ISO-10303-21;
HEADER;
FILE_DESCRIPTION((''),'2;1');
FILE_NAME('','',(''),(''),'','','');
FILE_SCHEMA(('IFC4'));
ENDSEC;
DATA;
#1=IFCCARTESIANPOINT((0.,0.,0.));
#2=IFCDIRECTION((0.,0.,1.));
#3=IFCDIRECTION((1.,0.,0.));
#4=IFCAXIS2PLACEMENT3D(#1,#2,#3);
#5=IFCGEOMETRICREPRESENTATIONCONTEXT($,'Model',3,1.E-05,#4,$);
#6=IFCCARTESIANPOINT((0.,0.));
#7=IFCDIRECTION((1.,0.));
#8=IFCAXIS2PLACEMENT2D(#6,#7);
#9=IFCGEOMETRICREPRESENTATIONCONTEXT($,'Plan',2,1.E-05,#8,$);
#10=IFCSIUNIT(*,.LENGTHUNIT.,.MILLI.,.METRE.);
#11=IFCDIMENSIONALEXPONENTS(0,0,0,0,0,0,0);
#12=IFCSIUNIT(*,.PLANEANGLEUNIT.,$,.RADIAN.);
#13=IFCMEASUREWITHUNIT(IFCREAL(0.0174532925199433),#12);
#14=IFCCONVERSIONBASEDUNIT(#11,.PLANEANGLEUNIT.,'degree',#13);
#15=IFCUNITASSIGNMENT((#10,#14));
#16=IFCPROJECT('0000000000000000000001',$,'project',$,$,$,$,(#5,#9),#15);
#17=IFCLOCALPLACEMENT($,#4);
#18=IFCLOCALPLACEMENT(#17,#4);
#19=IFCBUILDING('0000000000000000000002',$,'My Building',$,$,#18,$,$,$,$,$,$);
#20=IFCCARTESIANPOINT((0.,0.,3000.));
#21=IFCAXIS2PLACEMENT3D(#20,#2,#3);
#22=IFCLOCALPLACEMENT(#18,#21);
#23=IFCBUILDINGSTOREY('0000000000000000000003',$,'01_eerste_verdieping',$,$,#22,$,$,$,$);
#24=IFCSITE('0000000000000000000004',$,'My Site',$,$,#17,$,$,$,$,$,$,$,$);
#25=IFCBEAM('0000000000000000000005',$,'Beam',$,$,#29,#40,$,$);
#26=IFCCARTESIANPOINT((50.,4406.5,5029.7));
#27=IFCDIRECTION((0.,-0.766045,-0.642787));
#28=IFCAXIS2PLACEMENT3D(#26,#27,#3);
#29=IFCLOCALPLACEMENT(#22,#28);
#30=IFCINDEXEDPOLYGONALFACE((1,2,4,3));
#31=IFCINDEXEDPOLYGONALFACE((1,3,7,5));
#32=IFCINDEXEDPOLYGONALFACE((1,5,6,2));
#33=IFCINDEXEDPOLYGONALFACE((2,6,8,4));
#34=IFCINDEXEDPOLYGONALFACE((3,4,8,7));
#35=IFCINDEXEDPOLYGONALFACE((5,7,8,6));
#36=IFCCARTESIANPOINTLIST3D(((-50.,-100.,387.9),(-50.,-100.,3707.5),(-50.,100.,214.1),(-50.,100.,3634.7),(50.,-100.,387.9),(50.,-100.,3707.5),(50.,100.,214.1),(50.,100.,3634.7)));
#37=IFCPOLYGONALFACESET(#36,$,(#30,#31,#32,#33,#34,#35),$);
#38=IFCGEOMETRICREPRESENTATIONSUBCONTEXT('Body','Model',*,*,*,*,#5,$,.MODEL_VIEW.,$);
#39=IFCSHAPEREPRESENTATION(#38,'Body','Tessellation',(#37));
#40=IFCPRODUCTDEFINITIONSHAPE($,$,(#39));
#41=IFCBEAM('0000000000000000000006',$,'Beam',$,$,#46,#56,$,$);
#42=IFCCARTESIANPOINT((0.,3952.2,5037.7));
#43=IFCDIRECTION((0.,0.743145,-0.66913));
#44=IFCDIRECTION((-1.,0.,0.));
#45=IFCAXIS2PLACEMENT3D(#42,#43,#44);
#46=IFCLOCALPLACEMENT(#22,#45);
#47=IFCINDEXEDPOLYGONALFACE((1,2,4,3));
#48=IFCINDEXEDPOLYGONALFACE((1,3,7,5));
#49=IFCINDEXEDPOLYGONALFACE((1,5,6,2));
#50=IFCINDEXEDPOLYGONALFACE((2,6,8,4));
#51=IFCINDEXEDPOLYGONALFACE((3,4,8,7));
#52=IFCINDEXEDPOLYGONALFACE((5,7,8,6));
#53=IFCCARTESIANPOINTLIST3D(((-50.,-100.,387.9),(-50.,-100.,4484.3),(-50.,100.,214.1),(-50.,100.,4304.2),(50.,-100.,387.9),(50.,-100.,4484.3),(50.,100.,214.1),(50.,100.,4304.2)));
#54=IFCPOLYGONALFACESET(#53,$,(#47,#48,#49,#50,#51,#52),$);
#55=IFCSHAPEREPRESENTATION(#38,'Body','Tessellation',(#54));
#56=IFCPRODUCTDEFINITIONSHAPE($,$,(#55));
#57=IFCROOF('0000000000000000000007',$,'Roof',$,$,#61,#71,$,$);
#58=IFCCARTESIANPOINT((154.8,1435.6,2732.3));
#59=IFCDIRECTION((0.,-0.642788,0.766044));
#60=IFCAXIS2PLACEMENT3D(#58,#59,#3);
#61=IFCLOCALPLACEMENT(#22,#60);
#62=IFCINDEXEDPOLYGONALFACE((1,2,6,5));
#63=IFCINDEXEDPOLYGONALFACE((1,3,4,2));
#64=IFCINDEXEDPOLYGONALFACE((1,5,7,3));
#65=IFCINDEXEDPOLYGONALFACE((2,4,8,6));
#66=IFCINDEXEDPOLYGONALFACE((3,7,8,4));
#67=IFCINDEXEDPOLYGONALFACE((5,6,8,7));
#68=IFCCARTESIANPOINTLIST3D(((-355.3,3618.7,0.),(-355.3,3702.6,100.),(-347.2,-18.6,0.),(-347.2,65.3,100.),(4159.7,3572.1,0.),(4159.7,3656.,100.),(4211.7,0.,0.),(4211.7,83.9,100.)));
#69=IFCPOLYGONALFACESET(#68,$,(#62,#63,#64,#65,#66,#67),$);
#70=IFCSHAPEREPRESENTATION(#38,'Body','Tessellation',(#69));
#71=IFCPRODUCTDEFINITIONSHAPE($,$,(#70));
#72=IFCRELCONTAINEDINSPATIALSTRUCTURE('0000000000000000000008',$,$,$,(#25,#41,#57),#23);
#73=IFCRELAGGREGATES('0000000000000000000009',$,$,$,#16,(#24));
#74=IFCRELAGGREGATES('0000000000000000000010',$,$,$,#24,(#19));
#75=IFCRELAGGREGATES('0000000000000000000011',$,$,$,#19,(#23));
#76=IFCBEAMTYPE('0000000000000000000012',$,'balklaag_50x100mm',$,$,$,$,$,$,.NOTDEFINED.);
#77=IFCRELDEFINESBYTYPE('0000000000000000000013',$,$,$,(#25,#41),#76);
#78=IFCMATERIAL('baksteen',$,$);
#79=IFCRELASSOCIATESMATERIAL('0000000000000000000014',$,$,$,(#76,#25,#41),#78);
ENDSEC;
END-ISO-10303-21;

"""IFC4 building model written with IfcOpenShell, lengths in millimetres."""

from ifc_helpers import new_model, entity, si_unit, converted_unit, frame, origin_with_axes, origin_2d_with_axis, place, context, subcontext, project, spatial, line, indexed_curve, rectangle, outline, extrude, clip, halfspace, material, material_profile, profile_set, profile_usage, type_object, element, save


model = new_model("IFC4")

# Units and contexts
model_context = context("Model", 3, precision=1e-05, world=origin_with_axes())
plan_context = context("Plan", 2, precision=1e-05, world=origin_2d_with_axis())
body_context = subcontext(model_context, "Body", "Model", "MODEL_VIEW")
ifc_project = project(units=[si_unit("LENGTHUNIT", "METRE", prefix="MILLI"), converted_unit("PLANEANGLEUNIT", "degree", entity("IfcReal", 0.0174532925199433), si_unit("PLANEANGLEUNIT", "RADIAN"), dimensions=[0, 0, 0, 0, 0, 0, 0])], contexts=[model_context, plan_context])

# Site, building, storey
site_placement = place(None, origin_with_axes())
site = spatial("IfcSite", under=ifc_project, at=site_placement, Name="My Site")
building_placement = place(site_placement, origin_with_axes())
building = spatial("IfcBuilding", under=site, at=building_placement, Name="My Building")
storey_placement = place(building_placement, frame((0.0, 0.0, 3000.0), z_axis=(0.0, 0.0, 1.0), x_axis=(1.0, 0.0, 0.0)))
storey = spatial("IfcBuildingStorey", under=building, at=storey_placement, Name="01_eerste_verdieping")

# Beams
ifc_material = material(Name="baksteen")
ifc_material_profile_1 = material_profile(ifc_material, rectangle(XDim=100.0, YDim=200.0))
ifc_profile_set_1 = profile_set([ifc_material_profile_1])
beam_type_1 = type_object("IfcBeamType", Name="balklaag_50x100mm", PredefinedType="NOTDEFINED", material=ifc_profile_set_1)
ifc_profile_usage_1 = profile_usage(ifc_profile_set_1, cardinal=5)
beam_1_placement = place(storey_placement, frame((50.0, 4406.5, 5029.7), z_axis=(0.0, -0.766045, -0.642787), x_axis=(1.0, 0.0, 0.0)))
element("IfcBeam", 1, at=beam_1_placement, inside=storey, type_object=beam_type_1, material=ifc_profile_usage_1, Name="Beam", context=body_context, shape_type="Clipping", body=[
    clip(clip(extrude(rectangle(XDim=100.0, YDim=200.0), origin_with_axes(), (0.0, 0.0, 1.0), 4026.7), halfspace(frame((-50.0, -100.0, 3707.5), z_axis=(0.0, 0.342015, 0.939695), x_axis=(0.0, 0.939695, -0.342015)), False)), halfspace(frame((-50.0, 100.0, 214.1), z_axis=(0.0, -0.656057, -0.754711), x_axis=(0.0, -0.754711, 0.656057)), False)),
])
ifc_profile_usage_2 = profile_usage(ifc_profile_set_1, cardinal=5)
beam_2_placement = place(storey_placement, frame((0.0, 3952.2, 5037.7), z_axis=(0.0, 0.743145, -0.66913), x_axis=(-1.0, 0.0, 0.0)))
element("IfcBeam", 2, at=beam_2_placement, inside=storey, type_object=beam_type_1, material=ifc_profile_usage_2, Name="Beam", context=body_context, shape_type="Clipping", body=[
    clip(clip(extrude(rectangle(XDim=100.0, YDim=200.0), origin_with_axes(), (0.0, 0.0, 1.0), 4594.3), halfspace(frame((-100.0, -35.9, 4426.5), z_axis=(0.0, 0.669131, 0.743145), x_axis=(-1.0, 0.0, 0.0)), False)), halfspace(frame((0.0, 100.0, 214.1), z_axis=(0.0, -0.656059, -0.754709), x_axis=(0.0, -0.75471, 0.656059)), False)),
])

# Roof
roof_1_placement = place(storey_placement, frame((154.8, 1435.6, 2732.3), z_axis=(0.0, -0.642788, 0.766044), x_axis=(1.0, 0.0, 0.0)))
element("IfcRoof", 3, at=roof_1_placement, inside=storey, Name="Roof", context=body_context, shape_type="SweptSolid", body=[
    extrude(outline(indexed_curve([(-355.3, 3618.7), (-347.2, -18.6), (4211.7, 0.0), (4159.7, 3572.1)], segments=[line(3, 2), line(2, 1), line(1, 4), line(4, 3)], self_intersect=False)), None, (0.0, 0.642788, 0.766044), 130.5),
])

save(model, "model.ifc")
